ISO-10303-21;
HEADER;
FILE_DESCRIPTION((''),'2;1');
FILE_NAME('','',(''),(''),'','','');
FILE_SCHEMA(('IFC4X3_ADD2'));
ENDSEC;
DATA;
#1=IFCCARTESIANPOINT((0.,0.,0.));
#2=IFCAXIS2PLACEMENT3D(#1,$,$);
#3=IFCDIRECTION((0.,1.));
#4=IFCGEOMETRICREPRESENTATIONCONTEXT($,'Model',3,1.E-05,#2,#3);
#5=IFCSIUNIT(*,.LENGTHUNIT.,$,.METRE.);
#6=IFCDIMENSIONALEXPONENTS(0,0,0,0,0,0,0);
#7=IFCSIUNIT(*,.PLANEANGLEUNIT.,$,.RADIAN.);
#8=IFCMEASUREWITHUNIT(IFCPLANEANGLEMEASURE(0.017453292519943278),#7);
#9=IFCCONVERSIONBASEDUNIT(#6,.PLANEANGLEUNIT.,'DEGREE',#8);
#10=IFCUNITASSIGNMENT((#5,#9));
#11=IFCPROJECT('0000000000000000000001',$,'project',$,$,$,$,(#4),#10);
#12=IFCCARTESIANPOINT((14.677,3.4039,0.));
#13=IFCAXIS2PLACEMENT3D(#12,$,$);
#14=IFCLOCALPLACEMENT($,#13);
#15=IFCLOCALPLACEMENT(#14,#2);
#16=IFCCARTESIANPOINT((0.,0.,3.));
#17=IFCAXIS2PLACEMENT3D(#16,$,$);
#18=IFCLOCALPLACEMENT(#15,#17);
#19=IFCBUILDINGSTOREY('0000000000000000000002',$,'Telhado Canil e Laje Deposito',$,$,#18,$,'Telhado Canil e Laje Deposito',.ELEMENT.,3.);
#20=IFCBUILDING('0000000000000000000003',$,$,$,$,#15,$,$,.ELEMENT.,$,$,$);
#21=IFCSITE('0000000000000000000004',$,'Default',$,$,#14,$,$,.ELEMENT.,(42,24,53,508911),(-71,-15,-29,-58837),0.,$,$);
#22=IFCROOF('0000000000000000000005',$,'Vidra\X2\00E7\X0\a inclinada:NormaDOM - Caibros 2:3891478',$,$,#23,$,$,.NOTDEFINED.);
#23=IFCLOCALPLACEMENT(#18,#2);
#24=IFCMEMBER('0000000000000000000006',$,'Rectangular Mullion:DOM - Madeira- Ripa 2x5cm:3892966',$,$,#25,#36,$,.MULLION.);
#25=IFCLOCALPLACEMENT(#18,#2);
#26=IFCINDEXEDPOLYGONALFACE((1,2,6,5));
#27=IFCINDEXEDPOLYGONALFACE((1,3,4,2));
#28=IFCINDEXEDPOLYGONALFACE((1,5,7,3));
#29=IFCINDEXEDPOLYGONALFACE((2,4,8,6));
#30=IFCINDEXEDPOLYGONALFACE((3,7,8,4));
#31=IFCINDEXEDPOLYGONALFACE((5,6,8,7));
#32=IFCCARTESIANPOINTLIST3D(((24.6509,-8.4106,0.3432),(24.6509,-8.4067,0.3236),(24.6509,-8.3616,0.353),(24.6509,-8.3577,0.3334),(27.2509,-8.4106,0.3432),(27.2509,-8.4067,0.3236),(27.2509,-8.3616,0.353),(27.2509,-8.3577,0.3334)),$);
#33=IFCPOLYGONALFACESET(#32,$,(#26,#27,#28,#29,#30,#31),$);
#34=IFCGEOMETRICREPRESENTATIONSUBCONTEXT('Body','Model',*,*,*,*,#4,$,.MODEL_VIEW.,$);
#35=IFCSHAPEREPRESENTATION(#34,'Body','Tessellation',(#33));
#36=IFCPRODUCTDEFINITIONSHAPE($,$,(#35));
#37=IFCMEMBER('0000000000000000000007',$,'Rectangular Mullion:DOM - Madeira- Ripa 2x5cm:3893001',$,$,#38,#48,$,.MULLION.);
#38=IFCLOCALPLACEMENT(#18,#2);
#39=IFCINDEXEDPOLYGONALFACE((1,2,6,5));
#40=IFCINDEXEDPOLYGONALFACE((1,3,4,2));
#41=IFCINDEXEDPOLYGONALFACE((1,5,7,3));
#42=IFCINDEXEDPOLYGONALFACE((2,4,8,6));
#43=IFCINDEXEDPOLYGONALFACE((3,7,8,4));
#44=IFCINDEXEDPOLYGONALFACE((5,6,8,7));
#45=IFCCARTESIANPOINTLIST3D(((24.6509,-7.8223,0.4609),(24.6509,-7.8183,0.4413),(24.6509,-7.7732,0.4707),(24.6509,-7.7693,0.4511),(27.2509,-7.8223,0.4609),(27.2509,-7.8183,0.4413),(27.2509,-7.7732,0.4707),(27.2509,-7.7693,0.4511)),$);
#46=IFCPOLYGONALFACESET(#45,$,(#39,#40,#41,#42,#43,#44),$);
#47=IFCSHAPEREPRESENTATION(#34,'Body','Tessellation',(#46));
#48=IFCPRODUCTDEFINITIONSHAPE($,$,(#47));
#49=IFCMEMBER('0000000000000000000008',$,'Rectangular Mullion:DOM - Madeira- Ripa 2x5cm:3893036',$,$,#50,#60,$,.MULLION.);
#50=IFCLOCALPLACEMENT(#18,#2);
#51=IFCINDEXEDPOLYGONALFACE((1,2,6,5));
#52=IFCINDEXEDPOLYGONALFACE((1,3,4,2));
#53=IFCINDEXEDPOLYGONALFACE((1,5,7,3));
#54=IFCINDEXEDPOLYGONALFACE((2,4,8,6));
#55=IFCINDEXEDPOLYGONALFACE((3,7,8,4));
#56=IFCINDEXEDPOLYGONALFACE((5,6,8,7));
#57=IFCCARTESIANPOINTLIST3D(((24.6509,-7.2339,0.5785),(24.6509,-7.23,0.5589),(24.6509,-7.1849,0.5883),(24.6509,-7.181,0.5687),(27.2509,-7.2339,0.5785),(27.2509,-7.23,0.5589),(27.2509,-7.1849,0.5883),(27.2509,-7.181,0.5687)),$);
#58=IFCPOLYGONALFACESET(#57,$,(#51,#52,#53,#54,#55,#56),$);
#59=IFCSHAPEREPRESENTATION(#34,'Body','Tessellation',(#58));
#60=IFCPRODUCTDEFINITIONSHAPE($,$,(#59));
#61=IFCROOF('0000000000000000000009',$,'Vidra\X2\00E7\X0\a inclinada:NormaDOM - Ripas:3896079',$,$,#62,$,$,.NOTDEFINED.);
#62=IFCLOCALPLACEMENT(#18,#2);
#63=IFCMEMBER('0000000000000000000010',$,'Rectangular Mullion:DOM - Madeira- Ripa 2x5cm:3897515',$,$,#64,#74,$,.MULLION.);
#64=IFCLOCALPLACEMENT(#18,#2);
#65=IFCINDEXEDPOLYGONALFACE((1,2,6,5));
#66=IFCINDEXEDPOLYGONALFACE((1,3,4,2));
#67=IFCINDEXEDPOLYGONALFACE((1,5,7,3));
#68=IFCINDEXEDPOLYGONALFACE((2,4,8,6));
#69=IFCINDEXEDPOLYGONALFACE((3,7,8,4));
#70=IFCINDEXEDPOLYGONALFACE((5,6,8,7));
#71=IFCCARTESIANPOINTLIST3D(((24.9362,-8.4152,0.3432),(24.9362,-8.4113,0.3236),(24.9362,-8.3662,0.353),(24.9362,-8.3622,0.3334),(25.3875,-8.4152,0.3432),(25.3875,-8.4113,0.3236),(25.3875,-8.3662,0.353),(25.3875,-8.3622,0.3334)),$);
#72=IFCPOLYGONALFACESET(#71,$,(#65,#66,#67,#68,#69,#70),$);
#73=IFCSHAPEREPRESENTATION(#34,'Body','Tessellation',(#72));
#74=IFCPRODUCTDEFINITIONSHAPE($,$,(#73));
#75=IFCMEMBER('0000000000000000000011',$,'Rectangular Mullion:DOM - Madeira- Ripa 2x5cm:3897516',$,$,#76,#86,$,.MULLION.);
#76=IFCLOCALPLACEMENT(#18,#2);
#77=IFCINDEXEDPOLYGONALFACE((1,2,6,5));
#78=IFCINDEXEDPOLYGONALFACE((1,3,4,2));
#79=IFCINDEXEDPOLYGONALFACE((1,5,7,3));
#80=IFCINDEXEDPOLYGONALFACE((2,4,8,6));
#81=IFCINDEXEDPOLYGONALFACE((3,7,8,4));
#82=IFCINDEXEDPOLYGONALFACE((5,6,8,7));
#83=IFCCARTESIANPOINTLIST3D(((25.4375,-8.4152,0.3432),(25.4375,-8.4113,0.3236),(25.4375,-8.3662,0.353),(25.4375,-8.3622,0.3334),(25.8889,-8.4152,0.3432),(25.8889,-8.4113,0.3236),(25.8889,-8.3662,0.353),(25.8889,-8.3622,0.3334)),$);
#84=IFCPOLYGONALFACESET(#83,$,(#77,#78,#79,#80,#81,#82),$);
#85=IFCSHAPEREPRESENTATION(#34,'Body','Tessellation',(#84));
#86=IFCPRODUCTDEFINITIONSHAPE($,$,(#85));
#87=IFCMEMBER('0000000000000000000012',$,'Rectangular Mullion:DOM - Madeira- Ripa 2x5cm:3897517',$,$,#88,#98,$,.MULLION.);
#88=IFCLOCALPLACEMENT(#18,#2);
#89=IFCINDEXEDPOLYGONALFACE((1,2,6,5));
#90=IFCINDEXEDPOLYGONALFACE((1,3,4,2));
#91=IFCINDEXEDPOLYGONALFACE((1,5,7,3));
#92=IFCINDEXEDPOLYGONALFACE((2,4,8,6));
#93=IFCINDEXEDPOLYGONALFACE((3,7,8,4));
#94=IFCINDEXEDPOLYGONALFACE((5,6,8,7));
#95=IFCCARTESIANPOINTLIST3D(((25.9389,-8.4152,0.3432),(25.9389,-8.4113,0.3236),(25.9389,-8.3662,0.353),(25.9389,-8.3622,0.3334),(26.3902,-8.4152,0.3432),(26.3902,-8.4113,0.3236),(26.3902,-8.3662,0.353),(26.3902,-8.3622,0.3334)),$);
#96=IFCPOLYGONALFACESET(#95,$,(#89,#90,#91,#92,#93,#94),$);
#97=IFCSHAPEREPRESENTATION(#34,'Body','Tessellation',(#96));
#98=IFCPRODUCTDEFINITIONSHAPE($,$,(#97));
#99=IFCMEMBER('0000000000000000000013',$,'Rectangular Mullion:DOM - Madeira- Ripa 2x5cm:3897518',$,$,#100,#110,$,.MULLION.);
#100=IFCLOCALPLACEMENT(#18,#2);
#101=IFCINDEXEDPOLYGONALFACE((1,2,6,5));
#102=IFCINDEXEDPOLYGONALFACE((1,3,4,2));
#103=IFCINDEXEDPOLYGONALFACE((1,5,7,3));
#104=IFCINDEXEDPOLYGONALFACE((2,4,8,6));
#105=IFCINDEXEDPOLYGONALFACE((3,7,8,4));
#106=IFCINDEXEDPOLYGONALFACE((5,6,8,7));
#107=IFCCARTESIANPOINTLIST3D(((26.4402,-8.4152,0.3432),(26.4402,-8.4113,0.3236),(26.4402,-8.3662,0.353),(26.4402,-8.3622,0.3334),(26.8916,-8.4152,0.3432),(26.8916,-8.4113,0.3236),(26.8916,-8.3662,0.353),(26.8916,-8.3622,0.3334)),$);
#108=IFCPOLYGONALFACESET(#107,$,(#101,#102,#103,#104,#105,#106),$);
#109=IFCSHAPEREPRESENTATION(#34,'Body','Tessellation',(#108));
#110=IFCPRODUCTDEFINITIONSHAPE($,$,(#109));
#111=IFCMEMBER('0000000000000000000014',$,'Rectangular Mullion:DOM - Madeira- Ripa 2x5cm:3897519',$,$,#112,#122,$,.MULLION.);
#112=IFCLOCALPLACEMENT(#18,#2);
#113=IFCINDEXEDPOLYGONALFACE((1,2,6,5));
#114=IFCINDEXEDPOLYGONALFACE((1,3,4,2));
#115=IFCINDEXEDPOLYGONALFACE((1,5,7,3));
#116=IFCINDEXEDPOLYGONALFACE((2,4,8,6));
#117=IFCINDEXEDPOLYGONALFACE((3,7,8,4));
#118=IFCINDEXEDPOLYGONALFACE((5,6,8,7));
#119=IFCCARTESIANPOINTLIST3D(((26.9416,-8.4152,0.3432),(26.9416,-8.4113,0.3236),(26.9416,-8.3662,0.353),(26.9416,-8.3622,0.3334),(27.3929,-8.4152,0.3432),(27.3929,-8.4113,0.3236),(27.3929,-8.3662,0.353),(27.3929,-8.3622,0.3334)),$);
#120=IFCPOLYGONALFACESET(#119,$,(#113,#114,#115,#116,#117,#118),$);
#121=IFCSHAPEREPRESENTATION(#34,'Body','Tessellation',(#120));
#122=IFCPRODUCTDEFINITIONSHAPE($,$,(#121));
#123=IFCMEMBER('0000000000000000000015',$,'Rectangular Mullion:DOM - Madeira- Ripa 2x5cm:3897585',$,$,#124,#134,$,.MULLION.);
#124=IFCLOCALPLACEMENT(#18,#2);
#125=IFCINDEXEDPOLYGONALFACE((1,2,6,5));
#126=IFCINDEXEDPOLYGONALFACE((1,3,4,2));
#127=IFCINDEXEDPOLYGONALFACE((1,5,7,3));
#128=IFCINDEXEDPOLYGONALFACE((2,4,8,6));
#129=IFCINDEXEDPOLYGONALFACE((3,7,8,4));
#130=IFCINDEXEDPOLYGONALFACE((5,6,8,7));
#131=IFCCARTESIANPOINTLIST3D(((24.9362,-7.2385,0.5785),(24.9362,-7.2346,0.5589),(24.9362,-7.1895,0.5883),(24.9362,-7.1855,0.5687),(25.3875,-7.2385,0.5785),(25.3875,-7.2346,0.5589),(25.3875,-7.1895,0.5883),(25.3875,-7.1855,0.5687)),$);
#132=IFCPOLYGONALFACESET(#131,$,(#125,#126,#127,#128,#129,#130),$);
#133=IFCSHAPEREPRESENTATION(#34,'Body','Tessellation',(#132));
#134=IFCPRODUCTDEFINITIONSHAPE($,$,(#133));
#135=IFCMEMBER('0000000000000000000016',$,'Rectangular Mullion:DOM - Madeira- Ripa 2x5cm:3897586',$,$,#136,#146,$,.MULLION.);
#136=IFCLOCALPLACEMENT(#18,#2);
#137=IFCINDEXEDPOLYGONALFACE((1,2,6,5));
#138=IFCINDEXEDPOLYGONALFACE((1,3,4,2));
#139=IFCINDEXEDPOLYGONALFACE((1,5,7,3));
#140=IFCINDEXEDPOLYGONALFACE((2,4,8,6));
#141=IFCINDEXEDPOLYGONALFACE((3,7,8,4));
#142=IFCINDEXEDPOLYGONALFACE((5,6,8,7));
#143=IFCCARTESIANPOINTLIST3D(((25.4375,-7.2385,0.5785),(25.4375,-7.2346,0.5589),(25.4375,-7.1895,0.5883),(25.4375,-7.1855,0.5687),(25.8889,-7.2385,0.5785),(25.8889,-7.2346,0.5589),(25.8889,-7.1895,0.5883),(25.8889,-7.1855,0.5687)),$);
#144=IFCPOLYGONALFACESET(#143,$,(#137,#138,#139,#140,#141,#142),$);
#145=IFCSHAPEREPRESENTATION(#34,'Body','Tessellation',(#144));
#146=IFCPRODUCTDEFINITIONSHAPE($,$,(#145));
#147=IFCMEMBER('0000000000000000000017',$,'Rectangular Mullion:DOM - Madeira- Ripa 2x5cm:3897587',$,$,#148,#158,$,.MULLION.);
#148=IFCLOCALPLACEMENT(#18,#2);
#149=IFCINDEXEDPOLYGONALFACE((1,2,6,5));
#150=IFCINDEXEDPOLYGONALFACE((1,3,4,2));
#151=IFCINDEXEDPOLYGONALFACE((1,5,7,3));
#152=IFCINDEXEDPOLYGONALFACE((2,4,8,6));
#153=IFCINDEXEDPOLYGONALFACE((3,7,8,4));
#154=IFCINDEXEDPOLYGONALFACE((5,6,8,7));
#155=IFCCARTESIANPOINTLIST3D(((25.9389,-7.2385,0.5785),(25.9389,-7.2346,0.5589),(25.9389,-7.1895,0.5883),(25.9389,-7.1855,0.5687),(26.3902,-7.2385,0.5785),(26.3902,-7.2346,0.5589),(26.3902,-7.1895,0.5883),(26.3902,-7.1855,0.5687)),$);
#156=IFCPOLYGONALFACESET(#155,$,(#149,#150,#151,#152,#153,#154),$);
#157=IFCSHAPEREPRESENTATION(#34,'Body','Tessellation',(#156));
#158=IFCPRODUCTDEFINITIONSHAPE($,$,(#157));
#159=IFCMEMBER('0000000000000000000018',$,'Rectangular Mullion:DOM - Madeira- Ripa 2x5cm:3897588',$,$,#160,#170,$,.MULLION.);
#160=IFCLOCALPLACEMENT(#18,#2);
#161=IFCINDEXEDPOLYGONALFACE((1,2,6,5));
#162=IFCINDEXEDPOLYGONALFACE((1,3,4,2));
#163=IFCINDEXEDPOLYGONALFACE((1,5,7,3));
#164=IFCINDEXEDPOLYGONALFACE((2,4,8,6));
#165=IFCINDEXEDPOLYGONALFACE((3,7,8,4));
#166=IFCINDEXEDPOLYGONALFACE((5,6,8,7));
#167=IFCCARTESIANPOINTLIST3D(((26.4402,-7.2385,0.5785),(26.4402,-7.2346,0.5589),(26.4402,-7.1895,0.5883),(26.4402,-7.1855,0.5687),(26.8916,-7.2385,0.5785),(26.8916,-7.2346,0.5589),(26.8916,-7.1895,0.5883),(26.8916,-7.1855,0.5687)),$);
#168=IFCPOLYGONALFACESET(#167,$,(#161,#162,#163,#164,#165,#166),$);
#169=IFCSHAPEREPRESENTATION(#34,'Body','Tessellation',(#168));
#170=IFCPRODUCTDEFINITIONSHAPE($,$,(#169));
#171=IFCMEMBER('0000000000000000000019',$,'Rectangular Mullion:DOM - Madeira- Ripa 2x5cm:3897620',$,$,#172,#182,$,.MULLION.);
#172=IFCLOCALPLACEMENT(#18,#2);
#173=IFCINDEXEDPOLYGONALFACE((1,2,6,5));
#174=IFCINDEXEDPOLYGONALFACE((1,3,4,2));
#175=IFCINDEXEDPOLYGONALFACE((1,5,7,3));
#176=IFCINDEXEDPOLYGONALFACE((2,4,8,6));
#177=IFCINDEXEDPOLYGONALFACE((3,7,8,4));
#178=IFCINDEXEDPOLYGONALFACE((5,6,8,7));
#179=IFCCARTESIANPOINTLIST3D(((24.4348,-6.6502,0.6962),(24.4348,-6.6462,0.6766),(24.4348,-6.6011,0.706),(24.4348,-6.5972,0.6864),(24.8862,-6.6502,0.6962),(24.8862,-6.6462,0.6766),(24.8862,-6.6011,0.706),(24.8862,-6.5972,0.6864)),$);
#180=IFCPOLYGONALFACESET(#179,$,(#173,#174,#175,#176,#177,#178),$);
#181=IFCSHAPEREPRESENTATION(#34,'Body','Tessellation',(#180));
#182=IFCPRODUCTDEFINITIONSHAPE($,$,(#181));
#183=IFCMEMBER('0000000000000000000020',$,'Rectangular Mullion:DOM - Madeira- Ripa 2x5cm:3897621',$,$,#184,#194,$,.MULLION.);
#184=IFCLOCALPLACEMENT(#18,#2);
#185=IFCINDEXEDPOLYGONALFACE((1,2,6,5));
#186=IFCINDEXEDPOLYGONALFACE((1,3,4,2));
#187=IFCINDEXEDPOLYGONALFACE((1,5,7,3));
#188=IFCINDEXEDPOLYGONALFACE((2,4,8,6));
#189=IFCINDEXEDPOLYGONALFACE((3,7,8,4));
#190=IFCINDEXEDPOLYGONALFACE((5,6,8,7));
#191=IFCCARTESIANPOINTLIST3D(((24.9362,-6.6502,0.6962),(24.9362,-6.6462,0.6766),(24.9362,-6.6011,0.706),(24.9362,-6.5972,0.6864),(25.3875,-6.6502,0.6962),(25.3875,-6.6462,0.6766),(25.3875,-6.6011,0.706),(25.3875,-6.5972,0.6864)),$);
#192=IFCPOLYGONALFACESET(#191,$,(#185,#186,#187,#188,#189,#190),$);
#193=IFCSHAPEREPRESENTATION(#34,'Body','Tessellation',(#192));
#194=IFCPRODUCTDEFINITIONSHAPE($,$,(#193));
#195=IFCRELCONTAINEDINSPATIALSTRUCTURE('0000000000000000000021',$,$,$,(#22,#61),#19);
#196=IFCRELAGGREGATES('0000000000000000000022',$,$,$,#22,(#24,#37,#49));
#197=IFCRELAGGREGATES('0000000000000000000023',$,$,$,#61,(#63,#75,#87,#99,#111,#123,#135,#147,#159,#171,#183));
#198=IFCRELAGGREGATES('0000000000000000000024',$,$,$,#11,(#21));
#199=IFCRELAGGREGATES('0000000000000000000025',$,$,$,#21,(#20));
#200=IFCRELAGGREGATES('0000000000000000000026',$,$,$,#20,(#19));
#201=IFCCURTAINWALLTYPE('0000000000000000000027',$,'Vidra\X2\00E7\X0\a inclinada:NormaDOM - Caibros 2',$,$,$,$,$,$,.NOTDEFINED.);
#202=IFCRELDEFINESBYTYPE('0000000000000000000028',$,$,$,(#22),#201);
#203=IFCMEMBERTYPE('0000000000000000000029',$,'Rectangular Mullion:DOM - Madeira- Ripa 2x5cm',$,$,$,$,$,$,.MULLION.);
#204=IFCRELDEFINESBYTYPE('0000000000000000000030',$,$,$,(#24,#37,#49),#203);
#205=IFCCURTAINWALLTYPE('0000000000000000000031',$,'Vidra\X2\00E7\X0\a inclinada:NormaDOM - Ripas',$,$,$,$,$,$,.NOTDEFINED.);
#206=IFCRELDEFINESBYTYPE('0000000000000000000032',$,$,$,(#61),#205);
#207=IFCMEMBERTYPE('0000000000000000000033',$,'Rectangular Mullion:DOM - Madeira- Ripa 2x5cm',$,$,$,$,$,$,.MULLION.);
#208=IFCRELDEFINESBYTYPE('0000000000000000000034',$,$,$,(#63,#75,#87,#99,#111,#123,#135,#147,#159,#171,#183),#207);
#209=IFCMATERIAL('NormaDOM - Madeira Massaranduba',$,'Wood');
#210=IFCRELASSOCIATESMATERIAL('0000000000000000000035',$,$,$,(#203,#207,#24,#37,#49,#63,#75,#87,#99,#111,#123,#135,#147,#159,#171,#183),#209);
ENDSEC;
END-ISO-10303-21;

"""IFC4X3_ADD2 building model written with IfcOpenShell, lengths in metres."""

from ifc_helpers import new_model, entity, si_unit, converted_unit, direction, frame, origin, origin_2d_with_axis, place, context, subcontext, project, spatial, rectangle, extrude, source, transform, mapped, material, material_profile, profile_set, profile_usage, type_object, type_shapes, element, aggregate, save


model = new_model("IFC4X3_ADD2")

# Units and contexts
model_context = context("Model", 3, precision=1e-05, world=origin(), true_north=direction((0.0, 1.0)))
body_context = subcontext(model_context, "Body", "Model", "MODEL_VIEW")
ifc_project = project(units=[si_unit("LENGTHUNIT", "METRE"), converted_unit("PLANEANGLEUNIT", "DEGREE", entity("IfcPlaneAngleMeasure", 0.017453292519943278), si_unit("PLANEANGLEUNIT", "RADIAN"), dimensions=[0, 0, 0, 0, 0, 0, 0])], contexts=[model_context])

# Site, building, storey
site_placement = place(None, frame((14.677, 3.4039, 0.0)))
site = spatial("IfcSite", under=ifc_project, at=site_placement, Name="Default", CompositionType="ELEMENT", RefLatitude=(42, 24, 53, 508911), RefLongitude=(-71, -15, -29, -58837), RefElevation=0.0)
building_placement = place(site_placement, origin())
building = spatial("IfcBuilding", under=site, at=building_placement, CompositionType="ELEMENT")
storey_placement = place(building_placement, frame((0.0, 0.0, 3.0)))
storey = spatial("IfcBuildingStorey", under=building, at=storey_placement, Name="Telhado Canil e Laje Deposito", LongName="Telhado Canil e Laje Deposito", CompositionType="ELEMENT", Elevation=3.0)

# Roofs, members
curtain_wall_type_1 = type_object("IfcCurtainWallType", Name="Vidraça inclinada:NormaDOM - Caibros 2", PredefinedType="NOTDEFINED")
roof_1_placement = place(storey_placement, frame((0.0, 0.0, -3.0)))
roof_1 = element("IfcRoof", 1, at=roof_1_placement, inside=storey, type_object=curtain_wall_type_1, Name="Vidraça inclinada:NormaDOM - Caibros 2:3891478", PredefinedType="NOTDEFINED")
ifc_material = material(Name="NormaDOM - Madeira Massaranduba", Category="Wood")
ifc_material_profile_1 = material_profile(ifc_material, rectangle(XDim=0.05, YDim=0.02, at=origin_2d_with_axis()), Name="DOM - Madeira- Ripa 2x5cm")
ifc_profile_set_1 = profile_set([ifc_material_profile_1], Name="DOM - Madeira- Ripa 2x5cm")
ifc_profile_usage_1 = profile_usage(ifc_profile_set_1)
member_type_1 = type_object("IfcMemberType", Name="Rectangular Mullion:DOM - Madeira- Ripa 2x5cm", PredefinedType="MULLION", material=ifc_profile_set_1)
shared_shape_1 = source(origin(), body_context, "Body", "SweptSolid", [
    extrude(rectangle(XDim=0.05, YDim=0.02, at=origin_2d_with_axis()), frame((0.025, 0.01, -2.6), z_axis=(0.0, 0.0, 1.0), x_axis=(-1.0, 0.0, 0.0)), (0.0, 0.0, 1.0), 2.6),
])
type_shapes(member_type_1, [shared_shape_1])
member_1_placement = place(roof_1_placement, frame((24.6509, -8.4106, 3.3432), z_axis=(-1.0, 0.0, 0.0), x_axis=(0.0, 0.980581, 0.196116)))
member_1 = element("IfcMember", 2, at=member_1_placement, type_object=member_type_1, material=ifc_profile_usage_1, Name="Rectangular Mullion:DOM - Madeira- Ripa 2x5cm:3892966", PredefinedType="MULLION", context=body_context, shape_type="MappedRepresentation", body=[
    mapped(shared_shape_1, transform((0.0, 0.0, 0.0), scale=1.0)),
])
member_2_placement = place(roof_1_placement, frame((24.6509, -7.8223, 3.4609), z_axis=(-1.0, 0.0, 0.0), x_axis=(0.0, 0.980581, 0.196116)))
member_2 = element("IfcMember", 3, at=member_2_placement, type_object=member_type_1, material=ifc_profile_usage_1, Name="Rectangular Mullion:DOM - Madeira- Ripa 2x5cm:3893001", PredefinedType="MULLION", context=body_context, shape_type="MappedRepresentation", body=[
    mapped(shared_shape_1, transform((0.0, 0.0, 0.0), scale=1.0)),
])
member_3_placement = place(roof_1_placement, frame((24.6509, -7.2339, 3.5785), z_axis=(-1.0, 0.0, 0.0), x_axis=(0.0, 0.980581, 0.196116)))
member_3 = element("IfcMember", 4, at=member_3_placement, type_object=member_type_1, material=ifc_profile_usage_1, Name="Rectangular Mullion:DOM - Madeira- Ripa 2x5cm:3893036", PredefinedType="MULLION", context=body_context, shape_type="MappedRepresentation", body=[
    mapped(shared_shape_1, transform((0.0, 0.0, 0.0), scale=1.0)),
])
aggregate(roof_1, [member_1, member_2, member_3])
curtain_wall_type_2 = type_object("IfcCurtainWallType", Name="Vidraça inclinada:NormaDOM - Ripas", PredefinedType="NOTDEFINED")
roof_2_placement = place(storey_placement, frame((0.0, 0.0, -3.0)))
roof_2 = element("IfcRoof", 5, at=roof_2_placement, inside=storey, type_object=curtain_wall_type_2, Name="Vidraça inclinada:NormaDOM - Ripas:3896079", PredefinedType="NOTDEFINED")
member_type_2 = type_object("IfcMemberType", Name="Rectangular Mullion:DOM - Madeira- Ripa 2x5cm", PredefinedType="MULLION", material=ifc_profile_set_1)
shared_shape_2 = source(origin(), body_context, "Body", "SweptSolid", [
    extrude(rectangle(XDim=0.05, YDim=0.02, at=origin_2d_with_axis()), frame((0.025, 0.01, -0.4514), z_axis=(0.0, 0.0, 1.0), x_axis=(-1.0, 0.0, 0.0)), (0.0, 0.0, 1.0), 0.4514),
])
type_shapes(member_type_2, [shared_shape_2])
member_4_placement = place(roof_2_placement, frame((24.9362, -8.4152, 3.3432), z_axis=(-1.0, 0.0, 0.0), x_axis=(0.0, 0.980581, 0.196116)))
member_4 = element("IfcMember", 6, at=member_4_placement, type_object=member_type_2, material=ifc_profile_usage_1, Name="Rectangular Mullion:DOM - Madeira- Ripa 2x5cm:3897515", PredefinedType="MULLION", context=body_context, shape_type="MappedRepresentation", body=[
    mapped(shared_shape_2, transform((0.0, 0.0, 0.0), scale=1.0)),
])
member_5_placement = place(roof_2_placement, frame((25.4375, -8.4152, 3.3432), z_axis=(-1.0, 0.0, 0.0), x_axis=(0.0, 0.980581, 0.196116)))
member_5 = element("IfcMember", 7, at=member_5_placement, type_object=member_type_2, material=ifc_profile_usage_1, Name="Rectangular Mullion:DOM - Madeira- Ripa 2x5cm:3897516", PredefinedType="MULLION", context=body_context, shape_type="MappedRepresentation", body=[
    mapped(shared_shape_2, transform((0.0, 0.0, 0.0), scale=1.0)),
])
member_6_placement = place(roof_2_placement, frame((25.9389, -8.4152, 3.3432), z_axis=(-1.0, 0.0, 0.0), x_axis=(0.0, 0.980581, 0.196116)))
member_6 = element("IfcMember", 8, at=member_6_placement, type_object=member_type_2, material=ifc_profile_usage_1, Name="Rectangular Mullion:DOM - Madeira- Ripa 2x5cm:3897517", PredefinedType="MULLION", context=body_context, shape_type="MappedRepresentation", body=[
    mapped(shared_shape_2, transform((0.0, 0.0, 0.0), scale=1.0)),
])
member_7_placement = place(roof_2_placement, frame((26.4402, -8.4152, 3.3432), z_axis=(-1.0, 0.0, 0.0), x_axis=(0.0, 0.980581, 0.196116)))
member_7 = element("IfcMember", 9, at=member_7_placement, type_object=member_type_2, material=ifc_profile_usage_1, Name="Rectangular Mullion:DOM - Madeira- Ripa 2x5cm:3897518", PredefinedType="MULLION", context=body_context, shape_type="MappedRepresentation", body=[
    mapped(shared_shape_2, transform((0.0, 0.0, 0.0), scale=1.0)),
])
member_8_placement = place(roof_2_placement, frame((26.9416, -8.4152, 3.3432), z_axis=(-1.0, 0.0, 0.0), x_axis=(0.0, 0.980581, 0.196116)))
member_8 = element("IfcMember", 10, at=member_8_placement, type_object=member_type_2, material=ifc_profile_usage_1, Name="Rectangular Mullion:DOM - Madeira- Ripa 2x5cm:3897519", PredefinedType="MULLION", context=body_context, shape_type="MappedRepresentation", body=[
    mapped(shared_shape_2, transform((0.0, 0.0, 0.0), scale=1.0)),
])
member_9_placement = place(roof_2_placement, frame((24.9362, -7.2385, 3.5785), z_axis=(-1.0, 0.0, 0.0), x_axis=(0.0, 0.980581, 0.196116)))
member_9 = element("IfcMember", 11, at=member_9_placement, type_object=member_type_2, material=ifc_profile_usage_1, Name="Rectangular Mullion:DOM - Madeira- Ripa 2x5cm:3897585", PredefinedType="MULLION", context=body_context, shape_type="MappedRepresentation", body=[
    mapped(shared_shape_2, transform((0.0, 0.0, 0.0), scale=1.0)),
])
member_10_placement = place(roof_2_placement, frame((25.4375, -7.2385, 3.5785), z_axis=(-1.0, 0.0, 0.0), x_axis=(0.0, 0.980581, 0.196116)))
member_10 = element("IfcMember", 12, at=member_10_placement, type_object=member_type_2, material=ifc_profile_usage_1, Name="Rectangular Mullion:DOM - Madeira- Ripa 2x5cm:3897586", PredefinedType="MULLION", context=body_context, shape_type="MappedRepresentation", body=[
    mapped(shared_shape_2, transform((0.0, 0.0, 0.0), scale=1.0)),
])
member_11_placement = place(roof_2_placement, frame((25.9389, -7.2385, 3.5785), z_axis=(-1.0, 0.0, 0.0), x_axis=(0.0, 0.980581, 0.196116)))
member_11 = element("IfcMember", 13, at=member_11_placement, type_object=member_type_2, material=ifc_profile_usage_1, Name="Rectangular Mullion:DOM - Madeira- Ripa 2x5cm:3897587", PredefinedType="MULLION", context=body_context, shape_type="MappedRepresentation", body=[
    mapped(shared_shape_2, transform((0.0, 0.0, 0.0), scale=1.0)),
])
member_12_placement = place(roof_2_placement, frame((26.4402, -7.2385, 3.5785), z_axis=(-1.0, 0.0, 0.0), x_axis=(0.0, 0.980581, 0.196116)))
member_12 = element("IfcMember", 14, at=member_12_placement, type_object=member_type_2, material=ifc_profile_usage_1, Name="Rectangular Mullion:DOM - Madeira- Ripa 2x5cm:3897588", PredefinedType="MULLION", context=body_context, shape_type="MappedRepresentation", body=[
    mapped(shared_shape_2, transform((0.0, 0.0, 0.0), scale=1.0)),
])
member_13_placement = place(roof_2_placement, frame((24.4348, -6.6502, 3.6962), z_axis=(-1.0, 0.0, 0.0), x_axis=(0.0, 0.980581, 0.196116)))
member_13 = element("IfcMember", 15, at=member_13_placement, type_object=member_type_2, material=ifc_profile_usage_1, Name="Rectangular Mullion:DOM - Madeira- Ripa 2x5cm:3897620", PredefinedType="MULLION", context=body_context, shape_type="MappedRepresentation", body=[
    mapped(shared_shape_2, transform((0.0, 0.0, 0.0), scale=1.0)),
])
member_14_placement = place(roof_2_placement, frame((24.9362, -6.6502, 3.6962), z_axis=(-1.0, 0.0, 0.0), x_axis=(0.0, 0.980581, 0.196116)))
member_14 = element("IfcMember", 16, at=member_14_placement, type_object=member_type_2, material=ifc_profile_usage_1, Name="Rectangular Mullion:DOM - Madeira- Ripa 2x5cm:3897621", PredefinedType="MULLION", context=body_context, shape_type="MappedRepresentation", body=[
    mapped(shared_shape_2, transform((0.0, 0.0, 0.0), scale=1.0)),
])
aggregate(roof_2, [member_4, member_5, member_6, member_7, member_8, member_9, member_10, member_11, member_12, member_13, member_14])

save(model, "model.ifc")
